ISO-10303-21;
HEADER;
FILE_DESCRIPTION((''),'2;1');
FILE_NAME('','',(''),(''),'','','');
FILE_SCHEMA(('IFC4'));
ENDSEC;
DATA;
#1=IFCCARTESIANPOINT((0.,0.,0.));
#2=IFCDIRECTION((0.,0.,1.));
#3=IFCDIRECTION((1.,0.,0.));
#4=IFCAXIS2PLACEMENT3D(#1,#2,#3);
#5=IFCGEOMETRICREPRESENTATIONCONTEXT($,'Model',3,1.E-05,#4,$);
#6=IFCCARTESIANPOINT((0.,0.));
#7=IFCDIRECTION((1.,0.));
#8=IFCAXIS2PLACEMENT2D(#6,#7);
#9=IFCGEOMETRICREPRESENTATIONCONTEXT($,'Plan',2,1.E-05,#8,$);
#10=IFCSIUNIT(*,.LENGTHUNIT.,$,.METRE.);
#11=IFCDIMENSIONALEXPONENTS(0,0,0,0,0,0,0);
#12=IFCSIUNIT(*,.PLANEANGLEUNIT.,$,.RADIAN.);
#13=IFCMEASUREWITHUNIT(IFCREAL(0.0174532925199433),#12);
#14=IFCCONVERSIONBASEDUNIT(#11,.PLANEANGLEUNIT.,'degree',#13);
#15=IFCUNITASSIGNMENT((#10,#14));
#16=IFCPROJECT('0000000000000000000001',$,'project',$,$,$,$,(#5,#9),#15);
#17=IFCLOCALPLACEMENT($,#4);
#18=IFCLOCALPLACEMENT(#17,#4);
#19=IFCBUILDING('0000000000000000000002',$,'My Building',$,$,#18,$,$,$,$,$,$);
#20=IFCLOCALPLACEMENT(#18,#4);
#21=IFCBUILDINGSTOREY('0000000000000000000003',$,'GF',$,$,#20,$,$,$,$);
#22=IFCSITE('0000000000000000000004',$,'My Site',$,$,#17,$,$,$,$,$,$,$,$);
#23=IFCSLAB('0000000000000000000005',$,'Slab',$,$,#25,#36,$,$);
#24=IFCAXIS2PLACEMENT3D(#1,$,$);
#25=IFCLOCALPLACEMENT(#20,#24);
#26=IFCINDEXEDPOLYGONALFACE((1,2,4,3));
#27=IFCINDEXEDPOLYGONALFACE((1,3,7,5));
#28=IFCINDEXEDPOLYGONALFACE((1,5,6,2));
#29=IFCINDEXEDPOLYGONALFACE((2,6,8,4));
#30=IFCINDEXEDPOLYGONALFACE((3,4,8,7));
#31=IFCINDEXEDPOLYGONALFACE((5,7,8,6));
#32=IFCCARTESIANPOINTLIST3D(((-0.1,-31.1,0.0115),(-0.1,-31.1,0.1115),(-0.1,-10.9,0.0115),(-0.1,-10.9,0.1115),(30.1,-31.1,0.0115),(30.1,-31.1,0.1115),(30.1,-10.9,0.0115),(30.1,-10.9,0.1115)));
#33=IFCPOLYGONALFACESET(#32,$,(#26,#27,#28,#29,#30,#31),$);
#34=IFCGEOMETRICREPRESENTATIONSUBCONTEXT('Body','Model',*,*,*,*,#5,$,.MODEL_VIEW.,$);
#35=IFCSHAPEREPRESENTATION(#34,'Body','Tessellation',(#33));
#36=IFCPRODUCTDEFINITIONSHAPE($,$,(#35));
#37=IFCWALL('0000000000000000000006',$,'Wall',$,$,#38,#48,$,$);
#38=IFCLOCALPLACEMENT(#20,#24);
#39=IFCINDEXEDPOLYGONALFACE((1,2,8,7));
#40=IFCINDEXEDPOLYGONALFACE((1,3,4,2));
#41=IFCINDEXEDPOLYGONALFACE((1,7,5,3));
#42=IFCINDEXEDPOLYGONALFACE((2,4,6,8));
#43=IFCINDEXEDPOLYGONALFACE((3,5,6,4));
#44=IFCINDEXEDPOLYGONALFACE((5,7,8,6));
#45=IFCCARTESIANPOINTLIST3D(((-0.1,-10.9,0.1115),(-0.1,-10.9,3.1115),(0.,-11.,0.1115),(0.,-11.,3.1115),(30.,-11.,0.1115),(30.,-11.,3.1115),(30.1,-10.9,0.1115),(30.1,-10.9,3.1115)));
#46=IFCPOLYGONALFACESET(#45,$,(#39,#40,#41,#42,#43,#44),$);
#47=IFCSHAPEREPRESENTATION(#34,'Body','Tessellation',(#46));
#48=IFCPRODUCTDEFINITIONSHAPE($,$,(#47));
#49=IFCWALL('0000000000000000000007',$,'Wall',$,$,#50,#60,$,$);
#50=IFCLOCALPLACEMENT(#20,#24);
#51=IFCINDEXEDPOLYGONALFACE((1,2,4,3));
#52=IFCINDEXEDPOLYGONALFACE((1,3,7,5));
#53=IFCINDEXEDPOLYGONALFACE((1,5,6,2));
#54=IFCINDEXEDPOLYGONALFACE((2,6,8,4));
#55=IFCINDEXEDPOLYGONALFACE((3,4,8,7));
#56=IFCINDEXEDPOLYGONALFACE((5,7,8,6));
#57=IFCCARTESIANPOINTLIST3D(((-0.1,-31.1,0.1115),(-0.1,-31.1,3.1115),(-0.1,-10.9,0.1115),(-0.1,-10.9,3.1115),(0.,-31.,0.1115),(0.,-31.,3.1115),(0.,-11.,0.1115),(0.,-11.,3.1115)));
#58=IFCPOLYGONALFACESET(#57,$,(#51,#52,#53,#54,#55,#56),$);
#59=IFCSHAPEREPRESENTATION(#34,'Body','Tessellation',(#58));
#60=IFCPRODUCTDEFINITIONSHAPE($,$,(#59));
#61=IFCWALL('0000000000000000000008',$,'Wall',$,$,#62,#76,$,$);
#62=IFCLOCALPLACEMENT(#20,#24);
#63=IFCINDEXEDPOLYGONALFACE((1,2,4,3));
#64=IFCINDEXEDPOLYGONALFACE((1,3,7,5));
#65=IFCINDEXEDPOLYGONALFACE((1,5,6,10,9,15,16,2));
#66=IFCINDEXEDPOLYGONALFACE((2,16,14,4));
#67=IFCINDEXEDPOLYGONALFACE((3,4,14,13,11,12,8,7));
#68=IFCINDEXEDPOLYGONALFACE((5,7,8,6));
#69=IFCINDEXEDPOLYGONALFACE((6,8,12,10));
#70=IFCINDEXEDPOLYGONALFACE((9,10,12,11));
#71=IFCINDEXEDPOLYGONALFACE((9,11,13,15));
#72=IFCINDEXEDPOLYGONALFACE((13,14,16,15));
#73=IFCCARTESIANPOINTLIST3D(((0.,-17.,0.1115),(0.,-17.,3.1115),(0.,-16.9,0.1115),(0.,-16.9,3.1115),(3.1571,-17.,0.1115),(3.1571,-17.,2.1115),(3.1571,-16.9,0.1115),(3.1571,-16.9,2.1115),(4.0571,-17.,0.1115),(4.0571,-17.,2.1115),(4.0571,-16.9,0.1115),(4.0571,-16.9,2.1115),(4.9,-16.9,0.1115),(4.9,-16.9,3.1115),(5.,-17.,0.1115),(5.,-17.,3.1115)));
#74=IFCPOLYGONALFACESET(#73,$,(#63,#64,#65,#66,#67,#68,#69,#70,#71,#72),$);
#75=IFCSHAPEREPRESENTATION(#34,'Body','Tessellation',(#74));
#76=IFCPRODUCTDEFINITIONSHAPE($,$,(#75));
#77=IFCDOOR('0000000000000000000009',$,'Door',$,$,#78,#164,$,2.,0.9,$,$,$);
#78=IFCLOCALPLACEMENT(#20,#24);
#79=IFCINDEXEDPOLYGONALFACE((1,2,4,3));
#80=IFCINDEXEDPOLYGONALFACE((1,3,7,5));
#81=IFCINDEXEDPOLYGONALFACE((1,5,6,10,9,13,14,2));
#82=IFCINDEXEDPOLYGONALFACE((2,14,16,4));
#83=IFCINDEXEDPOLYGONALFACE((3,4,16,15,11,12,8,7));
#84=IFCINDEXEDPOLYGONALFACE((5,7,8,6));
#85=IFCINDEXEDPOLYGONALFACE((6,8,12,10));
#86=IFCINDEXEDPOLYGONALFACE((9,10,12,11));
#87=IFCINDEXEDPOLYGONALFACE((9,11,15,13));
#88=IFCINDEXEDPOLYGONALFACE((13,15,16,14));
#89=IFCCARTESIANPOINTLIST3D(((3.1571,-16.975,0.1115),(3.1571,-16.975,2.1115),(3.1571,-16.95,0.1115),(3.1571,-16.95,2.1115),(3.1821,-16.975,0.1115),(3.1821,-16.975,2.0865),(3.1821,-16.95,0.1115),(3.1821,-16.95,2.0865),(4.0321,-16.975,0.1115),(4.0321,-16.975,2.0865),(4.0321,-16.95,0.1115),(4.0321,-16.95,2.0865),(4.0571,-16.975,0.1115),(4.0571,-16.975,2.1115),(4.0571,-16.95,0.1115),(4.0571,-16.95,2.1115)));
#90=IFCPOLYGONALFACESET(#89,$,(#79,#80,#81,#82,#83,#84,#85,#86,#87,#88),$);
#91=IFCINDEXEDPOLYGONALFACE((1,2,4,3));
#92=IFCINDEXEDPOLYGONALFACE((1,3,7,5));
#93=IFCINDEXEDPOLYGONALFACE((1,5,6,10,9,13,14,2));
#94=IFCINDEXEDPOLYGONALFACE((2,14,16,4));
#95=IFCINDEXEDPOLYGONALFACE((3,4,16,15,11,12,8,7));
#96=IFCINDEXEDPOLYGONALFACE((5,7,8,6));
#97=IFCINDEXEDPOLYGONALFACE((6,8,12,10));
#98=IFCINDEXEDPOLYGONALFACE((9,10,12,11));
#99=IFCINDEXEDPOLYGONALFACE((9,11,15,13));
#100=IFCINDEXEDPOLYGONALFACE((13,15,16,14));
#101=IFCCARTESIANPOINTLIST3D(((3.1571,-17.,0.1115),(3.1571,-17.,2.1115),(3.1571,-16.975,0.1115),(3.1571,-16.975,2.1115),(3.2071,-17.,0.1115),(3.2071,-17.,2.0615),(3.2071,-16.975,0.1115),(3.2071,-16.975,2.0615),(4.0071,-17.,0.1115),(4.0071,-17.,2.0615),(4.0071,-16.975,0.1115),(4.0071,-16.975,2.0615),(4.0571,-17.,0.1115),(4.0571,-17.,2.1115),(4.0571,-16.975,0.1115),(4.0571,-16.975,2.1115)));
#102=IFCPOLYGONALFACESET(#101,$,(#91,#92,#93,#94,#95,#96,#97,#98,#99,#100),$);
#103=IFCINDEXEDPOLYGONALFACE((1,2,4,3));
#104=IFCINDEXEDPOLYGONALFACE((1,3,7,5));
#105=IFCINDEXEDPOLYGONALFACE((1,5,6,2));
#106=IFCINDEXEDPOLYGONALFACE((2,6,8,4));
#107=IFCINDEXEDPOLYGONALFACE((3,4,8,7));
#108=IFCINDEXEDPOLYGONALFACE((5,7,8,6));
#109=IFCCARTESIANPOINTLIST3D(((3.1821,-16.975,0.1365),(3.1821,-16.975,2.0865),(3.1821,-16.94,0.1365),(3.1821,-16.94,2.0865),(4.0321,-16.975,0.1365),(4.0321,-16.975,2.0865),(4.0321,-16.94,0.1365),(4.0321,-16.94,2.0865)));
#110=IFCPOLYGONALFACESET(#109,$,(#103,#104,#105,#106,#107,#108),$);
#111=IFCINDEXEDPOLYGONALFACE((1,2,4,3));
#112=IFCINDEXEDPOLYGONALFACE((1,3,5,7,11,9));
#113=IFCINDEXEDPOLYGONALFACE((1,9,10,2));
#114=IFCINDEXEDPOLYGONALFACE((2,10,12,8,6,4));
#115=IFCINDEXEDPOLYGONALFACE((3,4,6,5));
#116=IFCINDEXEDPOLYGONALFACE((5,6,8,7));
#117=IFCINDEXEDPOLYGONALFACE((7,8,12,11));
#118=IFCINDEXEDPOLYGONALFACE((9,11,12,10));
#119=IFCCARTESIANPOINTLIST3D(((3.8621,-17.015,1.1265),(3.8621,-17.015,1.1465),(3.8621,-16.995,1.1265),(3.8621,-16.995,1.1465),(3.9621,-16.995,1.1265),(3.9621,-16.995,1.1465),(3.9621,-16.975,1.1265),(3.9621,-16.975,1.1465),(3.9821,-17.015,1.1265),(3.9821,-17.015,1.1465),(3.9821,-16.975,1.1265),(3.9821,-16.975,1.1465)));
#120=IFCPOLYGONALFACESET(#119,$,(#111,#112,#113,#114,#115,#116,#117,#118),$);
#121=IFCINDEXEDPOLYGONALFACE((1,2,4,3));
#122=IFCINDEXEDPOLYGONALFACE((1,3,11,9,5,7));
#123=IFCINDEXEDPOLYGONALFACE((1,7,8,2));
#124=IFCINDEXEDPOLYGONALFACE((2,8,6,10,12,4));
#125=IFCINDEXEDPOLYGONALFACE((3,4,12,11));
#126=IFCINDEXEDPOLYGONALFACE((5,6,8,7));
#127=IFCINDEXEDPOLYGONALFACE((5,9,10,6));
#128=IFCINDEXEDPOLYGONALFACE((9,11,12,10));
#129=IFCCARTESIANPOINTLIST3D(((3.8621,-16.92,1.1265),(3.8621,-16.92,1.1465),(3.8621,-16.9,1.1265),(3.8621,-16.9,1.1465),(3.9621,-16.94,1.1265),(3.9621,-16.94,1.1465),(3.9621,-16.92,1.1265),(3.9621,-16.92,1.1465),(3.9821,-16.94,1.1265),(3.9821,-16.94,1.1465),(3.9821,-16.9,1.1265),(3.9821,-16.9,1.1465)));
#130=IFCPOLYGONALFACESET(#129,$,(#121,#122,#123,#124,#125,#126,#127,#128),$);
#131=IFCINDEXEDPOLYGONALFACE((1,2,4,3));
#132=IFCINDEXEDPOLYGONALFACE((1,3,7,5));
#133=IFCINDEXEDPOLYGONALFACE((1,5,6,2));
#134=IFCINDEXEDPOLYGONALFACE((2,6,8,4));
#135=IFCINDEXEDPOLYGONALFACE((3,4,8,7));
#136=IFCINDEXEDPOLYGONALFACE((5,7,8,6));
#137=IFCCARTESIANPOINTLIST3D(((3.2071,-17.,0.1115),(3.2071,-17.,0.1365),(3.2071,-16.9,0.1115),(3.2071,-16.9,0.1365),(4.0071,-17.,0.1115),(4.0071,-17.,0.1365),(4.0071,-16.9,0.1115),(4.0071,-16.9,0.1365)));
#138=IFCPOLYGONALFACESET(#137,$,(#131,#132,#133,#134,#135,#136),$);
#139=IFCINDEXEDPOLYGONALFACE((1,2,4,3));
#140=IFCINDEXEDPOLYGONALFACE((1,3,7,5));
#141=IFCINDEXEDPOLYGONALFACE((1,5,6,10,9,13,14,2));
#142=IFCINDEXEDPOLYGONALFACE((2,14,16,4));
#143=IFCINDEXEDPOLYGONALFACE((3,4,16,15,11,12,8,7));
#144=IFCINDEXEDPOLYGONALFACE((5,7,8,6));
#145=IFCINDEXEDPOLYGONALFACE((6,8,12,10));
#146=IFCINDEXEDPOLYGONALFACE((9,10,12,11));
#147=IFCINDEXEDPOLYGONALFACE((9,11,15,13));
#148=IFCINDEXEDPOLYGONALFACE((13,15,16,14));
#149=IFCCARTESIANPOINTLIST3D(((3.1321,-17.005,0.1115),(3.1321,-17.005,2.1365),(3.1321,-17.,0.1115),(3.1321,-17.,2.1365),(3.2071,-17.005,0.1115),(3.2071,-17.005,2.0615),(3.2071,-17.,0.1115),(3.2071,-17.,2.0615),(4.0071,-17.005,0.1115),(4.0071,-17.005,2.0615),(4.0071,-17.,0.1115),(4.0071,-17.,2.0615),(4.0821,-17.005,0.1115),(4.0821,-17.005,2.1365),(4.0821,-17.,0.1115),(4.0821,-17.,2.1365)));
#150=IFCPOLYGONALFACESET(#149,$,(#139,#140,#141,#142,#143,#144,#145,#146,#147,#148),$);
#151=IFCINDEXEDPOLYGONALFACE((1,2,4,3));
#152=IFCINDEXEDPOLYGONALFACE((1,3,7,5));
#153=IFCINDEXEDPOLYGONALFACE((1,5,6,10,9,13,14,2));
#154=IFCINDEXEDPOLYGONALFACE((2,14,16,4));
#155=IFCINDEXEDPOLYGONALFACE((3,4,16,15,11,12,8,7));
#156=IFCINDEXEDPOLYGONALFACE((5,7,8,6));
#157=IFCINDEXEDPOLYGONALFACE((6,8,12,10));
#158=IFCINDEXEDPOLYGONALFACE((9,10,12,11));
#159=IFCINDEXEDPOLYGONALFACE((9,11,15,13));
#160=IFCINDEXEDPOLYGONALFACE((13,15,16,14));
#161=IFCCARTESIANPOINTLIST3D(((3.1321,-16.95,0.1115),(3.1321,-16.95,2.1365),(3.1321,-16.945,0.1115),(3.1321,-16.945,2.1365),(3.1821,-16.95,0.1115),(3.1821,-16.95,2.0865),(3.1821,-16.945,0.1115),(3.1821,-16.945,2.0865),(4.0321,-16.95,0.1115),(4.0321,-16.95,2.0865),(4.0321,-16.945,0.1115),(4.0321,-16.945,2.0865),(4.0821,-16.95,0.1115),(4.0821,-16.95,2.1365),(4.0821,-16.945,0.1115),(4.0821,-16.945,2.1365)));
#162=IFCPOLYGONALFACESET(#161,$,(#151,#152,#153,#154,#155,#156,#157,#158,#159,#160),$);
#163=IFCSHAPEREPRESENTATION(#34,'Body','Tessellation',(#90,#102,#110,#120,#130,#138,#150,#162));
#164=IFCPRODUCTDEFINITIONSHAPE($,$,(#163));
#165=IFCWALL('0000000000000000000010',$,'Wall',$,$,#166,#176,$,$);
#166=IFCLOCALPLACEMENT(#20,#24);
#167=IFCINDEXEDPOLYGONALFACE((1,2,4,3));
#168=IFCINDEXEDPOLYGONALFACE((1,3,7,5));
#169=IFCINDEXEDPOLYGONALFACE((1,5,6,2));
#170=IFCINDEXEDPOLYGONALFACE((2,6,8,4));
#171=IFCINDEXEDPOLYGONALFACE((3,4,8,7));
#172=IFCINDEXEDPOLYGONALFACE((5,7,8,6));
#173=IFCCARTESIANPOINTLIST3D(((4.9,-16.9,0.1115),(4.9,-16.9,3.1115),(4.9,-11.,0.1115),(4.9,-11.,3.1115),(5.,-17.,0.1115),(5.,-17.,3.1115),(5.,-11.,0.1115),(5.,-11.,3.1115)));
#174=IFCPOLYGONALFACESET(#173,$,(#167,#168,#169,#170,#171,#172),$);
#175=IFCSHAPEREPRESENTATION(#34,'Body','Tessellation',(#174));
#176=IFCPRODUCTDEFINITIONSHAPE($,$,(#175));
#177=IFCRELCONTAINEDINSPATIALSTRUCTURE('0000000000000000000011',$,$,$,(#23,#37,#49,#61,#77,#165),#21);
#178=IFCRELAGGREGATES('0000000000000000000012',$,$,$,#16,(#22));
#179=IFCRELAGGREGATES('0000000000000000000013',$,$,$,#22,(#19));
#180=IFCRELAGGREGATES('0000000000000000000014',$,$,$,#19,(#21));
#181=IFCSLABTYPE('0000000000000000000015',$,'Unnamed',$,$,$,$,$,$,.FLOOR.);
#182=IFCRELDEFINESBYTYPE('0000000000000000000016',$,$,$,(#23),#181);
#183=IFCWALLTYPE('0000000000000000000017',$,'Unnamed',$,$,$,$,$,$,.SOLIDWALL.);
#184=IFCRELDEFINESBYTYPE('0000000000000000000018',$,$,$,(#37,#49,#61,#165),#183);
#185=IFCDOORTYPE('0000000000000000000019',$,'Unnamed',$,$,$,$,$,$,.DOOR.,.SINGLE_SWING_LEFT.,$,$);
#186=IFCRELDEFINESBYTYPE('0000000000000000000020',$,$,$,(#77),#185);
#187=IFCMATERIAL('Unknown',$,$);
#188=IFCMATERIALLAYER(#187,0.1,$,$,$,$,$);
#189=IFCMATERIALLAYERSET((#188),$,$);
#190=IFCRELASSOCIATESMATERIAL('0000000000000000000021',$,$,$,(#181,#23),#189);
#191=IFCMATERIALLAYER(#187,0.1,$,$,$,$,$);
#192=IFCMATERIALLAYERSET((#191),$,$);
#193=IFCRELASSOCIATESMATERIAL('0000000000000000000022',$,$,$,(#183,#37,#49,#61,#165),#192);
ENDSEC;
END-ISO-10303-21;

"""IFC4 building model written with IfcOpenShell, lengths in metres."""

from ifc_helpers import new_model, entity, si_unit, converted_unit, frame, origin_with_axes, origin_2d_with_axis, place, context, subcontext, project, spatial, line, indexed_curve, outline, extrude, shape, source, transform, mapped, material, layer, layer_set, layer_usage, type_object, type_shapes, element, fill, save


model = new_model("IFC4")

# Units and contexts
model_context = context("Model", 3, precision=1e-05, world=origin_with_axes())
plan_context = context("Plan", 2, precision=1e-05, world=origin_2d_with_axis())
body_context_1 = subcontext(model_context, "Body", "Model", "MODEL_VIEW")
body_context_2 = subcontext(plan_context, "Body", "Plan", "PLAN_VIEW")
ifc_project = project(units=[si_unit("LENGTHUNIT", "METRE"), converted_unit("PLANEANGLEUNIT", "degree", entity("IfcReal", 0.0174532925199433), si_unit("PLANEANGLEUNIT", "RADIAN"), dimensions=[0, 0, 0, 0, 0, 0, 0])], contexts=[model_context, plan_context])

# Site, building, storey
site_placement = place(None, origin_with_axes())
site = spatial("IfcSite", under=ifc_project, at=site_placement, Name="My Site")
building_placement = place(site_placement, origin_with_axes())
building = spatial("IfcBuilding", under=site, at=building_placement, Name="My Building")
storey_placement = place(building_placement, origin_with_axes())
storey = spatial("IfcBuildingStorey", under=building, at=storey_placement, Name="GF")

# Slab
ifc_material = material(Name="Unknown")
ifc_layer_1 = layer(ifc_material, 0.1)
ifc_layer_set_1 = layer_set([ifc_layer_1])
ifc_layer_usage_1 = layer_usage(ifc_layer_set_1, "AXIS3", "POSITIVE", -0.1)
slab_type = type_object("IfcSlabType", Name="Unnamed", PredefinedType="FLOOR", material=ifc_layer_set_1)
slab_placement = place(storey_placement, frame((-0.1, -10.9, 0.1115), z_axis=(0.0, 0.0, 1.0), x_axis=(1.0, 0.0, 0.0)))
element("IfcSlab", 1, at=slab_placement, inside=storey, type_object=slab_type, material=ifc_layer_usage_1, Name="Slab", context=body_context_1, shape_type="SweptSolid", body=[
    extrude(outline(indexed_curve([(0.0, 0.0), (30.2, 0.0), (30.2, -20.2), (0.0, -20.2), (0.0, 0.0)])), frame((0.0, 0.0, -0.1), z_axis=(0.0, 0.0, 1.0), x_axis=(1.0, 0.0, 0.0)), (0.0, 0.0, 1.0), 0.1),
])

# Walls
ifc_layer_2 = layer(ifc_material, 0.1)
ifc_layer_set_2 = layer_set([ifc_layer_2])
ifc_layer_usage_2 = layer_usage(ifc_layer_set_2, "AXIS2", "POSITIVE", 0.0)
wall_type = type_object("IfcWallType", Name="Unnamed", PredefinedType="SOLIDWALL", material=ifc_layer_set_2)
wall_1_placement = place(storey_placement, frame((0.0, -11.0, 0.1115), z_axis=(0.0, 0.0, 1.0), x_axis=(1.0, 0.0, 0.0)))
element("IfcWall", 2, at=wall_1_placement, inside=storey, type_object=wall_type, material=ifc_layer_usage_2, Name="Wall", context=body_context_1, shape_type="SweptSolid", body=[
    extrude(outline(indexed_curve([(0.0, 0.0), (-0.1, 0.1), (30.1, 0.1), (30.0, 0.0)], segments=[line(1, 2, 3, 4, 1)])), origin_with_axes(), (0.0, 0.0, 1.0), 3.0),
])
ifc_layer_usage_3 = layer_usage(ifc_layer_set_2, "AXIS2", "POSITIVE", 0.0)
wall_2_placement = place(storey_placement, frame((0.0, -31.0, 0.1115), z_axis=(0.0, 0.0, 1.0), x_axis=(0.0, 1.0, 0.0)))
element("IfcWall", 3, at=wall_2_placement, inside=storey, type_object=wall_type, material=ifc_layer_usage_3, Name="Wall", context=body_context_1, shape_type="SweptSolid", body=[
    extrude(outline(indexed_curve([(0.0, 0.0), (-0.1, 0.1), (20.1, 0.1), (20.0, 0.0)], segments=[line(1, 2, 3, 4, 1)])), origin_with_axes(), (0.0, 0.0, 1.0), 3.0),
])

# Wall, opening, door
ifc_layer_usage_4 = layer_usage(ifc_layer_set_2, "AXIS2", "POSITIVE", 0.0)
wall_3_placement = place(storey_placement, frame((0.0, -17.0, 0.1115), z_axis=(0.0, 0.0, 1.0), x_axis=(1.0, 0.0, 0.0)))
wall_3 = element("IfcWall", 4, at=wall_3_placement, inside=storey, type_object=wall_type, material=ifc_layer_usage_4, Name="Wall", context=body_context_1, shape_type="SweptSolid", body=[
    extrude(outline(indexed_curve([(0.0, 0.0), (0.0, 0.1), (4.9, 0.1), (5.0, 0.0)], segments=[line(1, 2, 3, 4, 1)])), origin_with_axes(), (0.0, 0.0, 1.0), 3.0),
])
shared_shape_1 = source(origin_with_axes(), body_context_1, "Body", "SweptSolid", [
    extrude(outline(indexed_curve([(0.0, 0.0), (0.9, 0.0), (0.9, 2.0), (0.0, 2.0)], segments=[line(1, 2, 3, 4, 1)])), frame((0.0, -0.6, 0.0), z_axis=(0.0, -1.0, 0.0), x_axis=(1.0, 0.0, 0.0)), (0.0, 0.0, -1.0), 1.2),
])
opening_1_placement = place(wall_3_placement, frame((3.1571, 0.0, 0.0), z_axis=(0.0, 0.0, 1.0), x_axis=(1.0, 0.0, 0.0)))
opening_1 = element("IfcOpeningElement", 5, at=opening_1_placement, cuts=wall_3, PredefinedType="OPENING", context=body_context_1, shape_type="MappedRepresentation", body=[
    mapped(shared_shape_1, transform((0.0, 0.0, 0.0), x_axis=(1.0, 0.0, 0.0), y_axis=(0.0, 1.0, 0.0), z_axis=(0.0, 0.0, 1.0), scale=1.0)),
])
door_type = type_object("IfcDoorType", Name="Unnamed", OperationType="SINGLE_SWING_LEFT", PredefinedType="DOOR")
shared_shape_2 = source(origin_with_axes(), body_context_1, "Body", "SweptSolid", [
    extrude(outline(indexed_curve([(0.0, 0.0), (0.0, 2.0), (0.9, 2.0), (0.9, 0.0), (0.875, 0.0), (0.875, 1.975), (0.025, 1.975), (0.025, 0.0)], segments=[line(1, 2, 3, 4, 5, 6, 7, 8, 1)])), frame((0.0, 0.025, 0.0), z_axis=(0.0, -1.0, 0.0), x_axis=(1.0, 0.0, 0.0)), (0.0, 0.0, -1.0), 0.025),
    extrude(outline(indexed_curve([(0.0, 0.0), (0.0, 2.0), (0.9, 2.0), (0.9, 0.0), (0.85, 0.0), (0.85, 1.95), (0.05, 1.95), (0.05, 0.0)], segments=[line(1, 2, 3, 4, 5, 6, 7, 8, 1)])), frame((0.0, 0.0, 0.0), z_axis=(0.0, -1.0, 0.0), x_axis=(1.0, 0.0, 0.0)), (0.0, 0.0, -1.0), 0.025),
    extrude(outline(indexed_curve([(0.0, 0.0), (0.85, 0.0), (0.85, 0.035), (0.0, 0.035)], segments=[line(1, 2, 3, 4, 1)])), frame((0.025, 0.025, 0.025), z_axis=(0.0, 0.0, 1.0), x_axis=(1.0, 0.0, 0.0)), (0.0, 0.0, 1.0), 1.95),
    extrude(outline(indexed_curve([(0.0, 0.0), (0.0, -0.04), (-0.12, -0.04), (-0.12, -0.02), (-0.02, -0.02), (-0.02, 0.0)], segments=[line(1, 2, 3, 4, 5, 6, 1)])), frame((0.825, 0.025, 1.015), z_axis=(0.0, 0.0, 1.0), x_axis=(1.0, 0.0, 0.0)), (0.0, 0.0, 1.0), 0.02),
    extrude(outline(indexed_curve([(0.0, 0.0), (0.0, 0.04), (-0.12, 0.04), (-0.12, 0.02), (-0.02, 0.02), (-0.02, 0.0)], segments=[line(1, 2, 3, 4, 5, 6, 1)])), frame((0.825, 0.06, 1.015), z_axis=(0.0, 0.0, 1.0), x_axis=(1.0, 0.0, 0.0)), (0.0, 0.0, 1.0), 0.02),
    extrude(outline(indexed_curve([(0.0, 0.0), (0.8, 0.0), (0.8, 0.1), (0.0, 0.1)], segments=[line(1, 2, 3, 4, 1)])), frame((0.05, 0.0, 0.0), z_axis=(0.0, 0.0, 1.0), x_axis=(1.0, 0.0, 0.0)), (0.0, 0.0, 1.0), 0.025),
    extrude(outline(indexed_curve([(0.0, 0.0), (0.0, 2.025), (0.95, 2.025), (0.95, 0.0), (0.875, 0.0), (0.875, 1.95), (0.075, 1.95), (0.075, 0.0)], segments=[line(1, 2, 3, 4, 5, 6, 7, 8, 1)])), frame((-0.025, -0.005, 0.0), z_axis=(0.0, -1.0, 0.0), x_axis=(1.0, 0.0, 0.0)), (0.0, 0.0, -1.0), 0.005),
    extrude(outline(indexed_curve([(0.0, 0.0), (0.0, 2.025), (0.95, 2.025), (0.95, 0.0), (0.9, 0.0), (0.9, 1.975), (0.05, 1.975), (0.05, 0.0)], segments=[line(1, 2, 3, 4, 5, 6, 7, 8, 1)])), frame((-0.025, 0.05, 0.0), z_axis=(0.0, -1.0, 0.0), x_axis=(1.0, 0.0, 0.0)), (0.0, 0.0, -1.0), 0.005),
])
shared_shape_3 = source(origin_with_axes(), body_context_2, "Body", "Curve2D", [
    entity("IfcIndexedPolyCurve", entity("IfcCartesianPointList2D", [[0.0, 0.0], [0.0, 0.05], [0.025, 0.05], [0.025, 0.025], [0.05, 0.025], [0.05, 0.0]]), [entity("IfcLineIndex", [1, 2, 3, 4, 5, 6, 1])]),
    entity("IfcIndexedPolyCurve", entity("IfcCartesianPointList2D", [[0.9, 0.0], [0.9, 0.05], [0.875, 0.05], [0.875, 0.025], [0.85, 0.025], [0.85, 0.0]]), [entity("IfcLineIndex", [1, 2, 3, 4, 5, 6, 1])]),
    entity("IfcTrimmedCurve", entity("IfcEllipse", entity("IfcAxis2Placement2D", entity("IfcCartesianPoint", [0.06, 0.05]), entity("IfcDirection", [1.0, 0.0])), 0.815, 0.85), [entity("IfcCartesianPoint", [0.875, 0.05])], [entity("IfcCartesianPoint", [0.06, 0.9])], True, "CARTESIAN"),
    entity("IfcIndexedPolyCurve", entity("IfcCartesianPointList2D", [[0.025, 0.05], [0.06, 0.05], [0.06, 0.9], [0.025, 0.9]]), [entity("IfcLineIndex", [1, 2, 3, 4, 1])]),
])
type_shapes(door_type, [shared_shape_2, shared_shape_3])
door_1_placement = place(opening_1_placement, frame((0.0, 0.0, 0.0), z_axis=(0.0, 0.0, 1.0), x_axis=(1.0, 0.0, 0.0)))
door_1 = element("IfcDoor", 6, at=door_1_placement, inside=storey, type_object=door_type, Name="Door", OverallHeight=2.0, OverallWidth=0.9, shapes=[
    shape(body_context_1, "Body", "MappedRepresentation", [mapped(shared_shape_2, transform((0.0, 0.0, 0.0), x_axis=(1.0, 0.0, 0.0), y_axis=(0.0, 1.0, 0.0), z_axis=(0.0, 0.0, 1.0), scale=1.0))]),
    shape(body_context_2, "Body", "MappedRepresentation", [mapped(shared_shape_3, transform((0.0, 0.0, 0.0), x_axis=(1.0, 0.0, 0.0), y_axis=(0.0, 1.0, 0.0), z_axis=(0.0, 0.0, 1.0), scale=1.0))]),
])
fill(opening_1, door_1)

# Wall
ifc_layer_usage_5 = layer_usage(ifc_layer_set_2, "AXIS2", "POSITIVE", 0.0)
wall_4_placement = place(storey_placement, frame((5.0, -17.0, 0.1115), z_axis=(0.0, 0.0, 1.0), x_axis=(0.0, 1.0, 0.0)))
element("IfcWall", 7, at=wall_4_placement, inside=storey, type_object=wall_type, material=ifc_layer_usage_5, Name="Wall", context=body_context_1, shape_type="SweptSolid", body=[
    extrude(outline(indexed_curve([(0.0, 0.0), (0.1, 0.1), (6.0, 0.1), (6.0, 0.0)], segments=[line(1, 2, 3, 4, 1)])), origin_with_axes(), (0.0, 0.0, 1.0), 3.0),
])

save(model, "model.ifc")
